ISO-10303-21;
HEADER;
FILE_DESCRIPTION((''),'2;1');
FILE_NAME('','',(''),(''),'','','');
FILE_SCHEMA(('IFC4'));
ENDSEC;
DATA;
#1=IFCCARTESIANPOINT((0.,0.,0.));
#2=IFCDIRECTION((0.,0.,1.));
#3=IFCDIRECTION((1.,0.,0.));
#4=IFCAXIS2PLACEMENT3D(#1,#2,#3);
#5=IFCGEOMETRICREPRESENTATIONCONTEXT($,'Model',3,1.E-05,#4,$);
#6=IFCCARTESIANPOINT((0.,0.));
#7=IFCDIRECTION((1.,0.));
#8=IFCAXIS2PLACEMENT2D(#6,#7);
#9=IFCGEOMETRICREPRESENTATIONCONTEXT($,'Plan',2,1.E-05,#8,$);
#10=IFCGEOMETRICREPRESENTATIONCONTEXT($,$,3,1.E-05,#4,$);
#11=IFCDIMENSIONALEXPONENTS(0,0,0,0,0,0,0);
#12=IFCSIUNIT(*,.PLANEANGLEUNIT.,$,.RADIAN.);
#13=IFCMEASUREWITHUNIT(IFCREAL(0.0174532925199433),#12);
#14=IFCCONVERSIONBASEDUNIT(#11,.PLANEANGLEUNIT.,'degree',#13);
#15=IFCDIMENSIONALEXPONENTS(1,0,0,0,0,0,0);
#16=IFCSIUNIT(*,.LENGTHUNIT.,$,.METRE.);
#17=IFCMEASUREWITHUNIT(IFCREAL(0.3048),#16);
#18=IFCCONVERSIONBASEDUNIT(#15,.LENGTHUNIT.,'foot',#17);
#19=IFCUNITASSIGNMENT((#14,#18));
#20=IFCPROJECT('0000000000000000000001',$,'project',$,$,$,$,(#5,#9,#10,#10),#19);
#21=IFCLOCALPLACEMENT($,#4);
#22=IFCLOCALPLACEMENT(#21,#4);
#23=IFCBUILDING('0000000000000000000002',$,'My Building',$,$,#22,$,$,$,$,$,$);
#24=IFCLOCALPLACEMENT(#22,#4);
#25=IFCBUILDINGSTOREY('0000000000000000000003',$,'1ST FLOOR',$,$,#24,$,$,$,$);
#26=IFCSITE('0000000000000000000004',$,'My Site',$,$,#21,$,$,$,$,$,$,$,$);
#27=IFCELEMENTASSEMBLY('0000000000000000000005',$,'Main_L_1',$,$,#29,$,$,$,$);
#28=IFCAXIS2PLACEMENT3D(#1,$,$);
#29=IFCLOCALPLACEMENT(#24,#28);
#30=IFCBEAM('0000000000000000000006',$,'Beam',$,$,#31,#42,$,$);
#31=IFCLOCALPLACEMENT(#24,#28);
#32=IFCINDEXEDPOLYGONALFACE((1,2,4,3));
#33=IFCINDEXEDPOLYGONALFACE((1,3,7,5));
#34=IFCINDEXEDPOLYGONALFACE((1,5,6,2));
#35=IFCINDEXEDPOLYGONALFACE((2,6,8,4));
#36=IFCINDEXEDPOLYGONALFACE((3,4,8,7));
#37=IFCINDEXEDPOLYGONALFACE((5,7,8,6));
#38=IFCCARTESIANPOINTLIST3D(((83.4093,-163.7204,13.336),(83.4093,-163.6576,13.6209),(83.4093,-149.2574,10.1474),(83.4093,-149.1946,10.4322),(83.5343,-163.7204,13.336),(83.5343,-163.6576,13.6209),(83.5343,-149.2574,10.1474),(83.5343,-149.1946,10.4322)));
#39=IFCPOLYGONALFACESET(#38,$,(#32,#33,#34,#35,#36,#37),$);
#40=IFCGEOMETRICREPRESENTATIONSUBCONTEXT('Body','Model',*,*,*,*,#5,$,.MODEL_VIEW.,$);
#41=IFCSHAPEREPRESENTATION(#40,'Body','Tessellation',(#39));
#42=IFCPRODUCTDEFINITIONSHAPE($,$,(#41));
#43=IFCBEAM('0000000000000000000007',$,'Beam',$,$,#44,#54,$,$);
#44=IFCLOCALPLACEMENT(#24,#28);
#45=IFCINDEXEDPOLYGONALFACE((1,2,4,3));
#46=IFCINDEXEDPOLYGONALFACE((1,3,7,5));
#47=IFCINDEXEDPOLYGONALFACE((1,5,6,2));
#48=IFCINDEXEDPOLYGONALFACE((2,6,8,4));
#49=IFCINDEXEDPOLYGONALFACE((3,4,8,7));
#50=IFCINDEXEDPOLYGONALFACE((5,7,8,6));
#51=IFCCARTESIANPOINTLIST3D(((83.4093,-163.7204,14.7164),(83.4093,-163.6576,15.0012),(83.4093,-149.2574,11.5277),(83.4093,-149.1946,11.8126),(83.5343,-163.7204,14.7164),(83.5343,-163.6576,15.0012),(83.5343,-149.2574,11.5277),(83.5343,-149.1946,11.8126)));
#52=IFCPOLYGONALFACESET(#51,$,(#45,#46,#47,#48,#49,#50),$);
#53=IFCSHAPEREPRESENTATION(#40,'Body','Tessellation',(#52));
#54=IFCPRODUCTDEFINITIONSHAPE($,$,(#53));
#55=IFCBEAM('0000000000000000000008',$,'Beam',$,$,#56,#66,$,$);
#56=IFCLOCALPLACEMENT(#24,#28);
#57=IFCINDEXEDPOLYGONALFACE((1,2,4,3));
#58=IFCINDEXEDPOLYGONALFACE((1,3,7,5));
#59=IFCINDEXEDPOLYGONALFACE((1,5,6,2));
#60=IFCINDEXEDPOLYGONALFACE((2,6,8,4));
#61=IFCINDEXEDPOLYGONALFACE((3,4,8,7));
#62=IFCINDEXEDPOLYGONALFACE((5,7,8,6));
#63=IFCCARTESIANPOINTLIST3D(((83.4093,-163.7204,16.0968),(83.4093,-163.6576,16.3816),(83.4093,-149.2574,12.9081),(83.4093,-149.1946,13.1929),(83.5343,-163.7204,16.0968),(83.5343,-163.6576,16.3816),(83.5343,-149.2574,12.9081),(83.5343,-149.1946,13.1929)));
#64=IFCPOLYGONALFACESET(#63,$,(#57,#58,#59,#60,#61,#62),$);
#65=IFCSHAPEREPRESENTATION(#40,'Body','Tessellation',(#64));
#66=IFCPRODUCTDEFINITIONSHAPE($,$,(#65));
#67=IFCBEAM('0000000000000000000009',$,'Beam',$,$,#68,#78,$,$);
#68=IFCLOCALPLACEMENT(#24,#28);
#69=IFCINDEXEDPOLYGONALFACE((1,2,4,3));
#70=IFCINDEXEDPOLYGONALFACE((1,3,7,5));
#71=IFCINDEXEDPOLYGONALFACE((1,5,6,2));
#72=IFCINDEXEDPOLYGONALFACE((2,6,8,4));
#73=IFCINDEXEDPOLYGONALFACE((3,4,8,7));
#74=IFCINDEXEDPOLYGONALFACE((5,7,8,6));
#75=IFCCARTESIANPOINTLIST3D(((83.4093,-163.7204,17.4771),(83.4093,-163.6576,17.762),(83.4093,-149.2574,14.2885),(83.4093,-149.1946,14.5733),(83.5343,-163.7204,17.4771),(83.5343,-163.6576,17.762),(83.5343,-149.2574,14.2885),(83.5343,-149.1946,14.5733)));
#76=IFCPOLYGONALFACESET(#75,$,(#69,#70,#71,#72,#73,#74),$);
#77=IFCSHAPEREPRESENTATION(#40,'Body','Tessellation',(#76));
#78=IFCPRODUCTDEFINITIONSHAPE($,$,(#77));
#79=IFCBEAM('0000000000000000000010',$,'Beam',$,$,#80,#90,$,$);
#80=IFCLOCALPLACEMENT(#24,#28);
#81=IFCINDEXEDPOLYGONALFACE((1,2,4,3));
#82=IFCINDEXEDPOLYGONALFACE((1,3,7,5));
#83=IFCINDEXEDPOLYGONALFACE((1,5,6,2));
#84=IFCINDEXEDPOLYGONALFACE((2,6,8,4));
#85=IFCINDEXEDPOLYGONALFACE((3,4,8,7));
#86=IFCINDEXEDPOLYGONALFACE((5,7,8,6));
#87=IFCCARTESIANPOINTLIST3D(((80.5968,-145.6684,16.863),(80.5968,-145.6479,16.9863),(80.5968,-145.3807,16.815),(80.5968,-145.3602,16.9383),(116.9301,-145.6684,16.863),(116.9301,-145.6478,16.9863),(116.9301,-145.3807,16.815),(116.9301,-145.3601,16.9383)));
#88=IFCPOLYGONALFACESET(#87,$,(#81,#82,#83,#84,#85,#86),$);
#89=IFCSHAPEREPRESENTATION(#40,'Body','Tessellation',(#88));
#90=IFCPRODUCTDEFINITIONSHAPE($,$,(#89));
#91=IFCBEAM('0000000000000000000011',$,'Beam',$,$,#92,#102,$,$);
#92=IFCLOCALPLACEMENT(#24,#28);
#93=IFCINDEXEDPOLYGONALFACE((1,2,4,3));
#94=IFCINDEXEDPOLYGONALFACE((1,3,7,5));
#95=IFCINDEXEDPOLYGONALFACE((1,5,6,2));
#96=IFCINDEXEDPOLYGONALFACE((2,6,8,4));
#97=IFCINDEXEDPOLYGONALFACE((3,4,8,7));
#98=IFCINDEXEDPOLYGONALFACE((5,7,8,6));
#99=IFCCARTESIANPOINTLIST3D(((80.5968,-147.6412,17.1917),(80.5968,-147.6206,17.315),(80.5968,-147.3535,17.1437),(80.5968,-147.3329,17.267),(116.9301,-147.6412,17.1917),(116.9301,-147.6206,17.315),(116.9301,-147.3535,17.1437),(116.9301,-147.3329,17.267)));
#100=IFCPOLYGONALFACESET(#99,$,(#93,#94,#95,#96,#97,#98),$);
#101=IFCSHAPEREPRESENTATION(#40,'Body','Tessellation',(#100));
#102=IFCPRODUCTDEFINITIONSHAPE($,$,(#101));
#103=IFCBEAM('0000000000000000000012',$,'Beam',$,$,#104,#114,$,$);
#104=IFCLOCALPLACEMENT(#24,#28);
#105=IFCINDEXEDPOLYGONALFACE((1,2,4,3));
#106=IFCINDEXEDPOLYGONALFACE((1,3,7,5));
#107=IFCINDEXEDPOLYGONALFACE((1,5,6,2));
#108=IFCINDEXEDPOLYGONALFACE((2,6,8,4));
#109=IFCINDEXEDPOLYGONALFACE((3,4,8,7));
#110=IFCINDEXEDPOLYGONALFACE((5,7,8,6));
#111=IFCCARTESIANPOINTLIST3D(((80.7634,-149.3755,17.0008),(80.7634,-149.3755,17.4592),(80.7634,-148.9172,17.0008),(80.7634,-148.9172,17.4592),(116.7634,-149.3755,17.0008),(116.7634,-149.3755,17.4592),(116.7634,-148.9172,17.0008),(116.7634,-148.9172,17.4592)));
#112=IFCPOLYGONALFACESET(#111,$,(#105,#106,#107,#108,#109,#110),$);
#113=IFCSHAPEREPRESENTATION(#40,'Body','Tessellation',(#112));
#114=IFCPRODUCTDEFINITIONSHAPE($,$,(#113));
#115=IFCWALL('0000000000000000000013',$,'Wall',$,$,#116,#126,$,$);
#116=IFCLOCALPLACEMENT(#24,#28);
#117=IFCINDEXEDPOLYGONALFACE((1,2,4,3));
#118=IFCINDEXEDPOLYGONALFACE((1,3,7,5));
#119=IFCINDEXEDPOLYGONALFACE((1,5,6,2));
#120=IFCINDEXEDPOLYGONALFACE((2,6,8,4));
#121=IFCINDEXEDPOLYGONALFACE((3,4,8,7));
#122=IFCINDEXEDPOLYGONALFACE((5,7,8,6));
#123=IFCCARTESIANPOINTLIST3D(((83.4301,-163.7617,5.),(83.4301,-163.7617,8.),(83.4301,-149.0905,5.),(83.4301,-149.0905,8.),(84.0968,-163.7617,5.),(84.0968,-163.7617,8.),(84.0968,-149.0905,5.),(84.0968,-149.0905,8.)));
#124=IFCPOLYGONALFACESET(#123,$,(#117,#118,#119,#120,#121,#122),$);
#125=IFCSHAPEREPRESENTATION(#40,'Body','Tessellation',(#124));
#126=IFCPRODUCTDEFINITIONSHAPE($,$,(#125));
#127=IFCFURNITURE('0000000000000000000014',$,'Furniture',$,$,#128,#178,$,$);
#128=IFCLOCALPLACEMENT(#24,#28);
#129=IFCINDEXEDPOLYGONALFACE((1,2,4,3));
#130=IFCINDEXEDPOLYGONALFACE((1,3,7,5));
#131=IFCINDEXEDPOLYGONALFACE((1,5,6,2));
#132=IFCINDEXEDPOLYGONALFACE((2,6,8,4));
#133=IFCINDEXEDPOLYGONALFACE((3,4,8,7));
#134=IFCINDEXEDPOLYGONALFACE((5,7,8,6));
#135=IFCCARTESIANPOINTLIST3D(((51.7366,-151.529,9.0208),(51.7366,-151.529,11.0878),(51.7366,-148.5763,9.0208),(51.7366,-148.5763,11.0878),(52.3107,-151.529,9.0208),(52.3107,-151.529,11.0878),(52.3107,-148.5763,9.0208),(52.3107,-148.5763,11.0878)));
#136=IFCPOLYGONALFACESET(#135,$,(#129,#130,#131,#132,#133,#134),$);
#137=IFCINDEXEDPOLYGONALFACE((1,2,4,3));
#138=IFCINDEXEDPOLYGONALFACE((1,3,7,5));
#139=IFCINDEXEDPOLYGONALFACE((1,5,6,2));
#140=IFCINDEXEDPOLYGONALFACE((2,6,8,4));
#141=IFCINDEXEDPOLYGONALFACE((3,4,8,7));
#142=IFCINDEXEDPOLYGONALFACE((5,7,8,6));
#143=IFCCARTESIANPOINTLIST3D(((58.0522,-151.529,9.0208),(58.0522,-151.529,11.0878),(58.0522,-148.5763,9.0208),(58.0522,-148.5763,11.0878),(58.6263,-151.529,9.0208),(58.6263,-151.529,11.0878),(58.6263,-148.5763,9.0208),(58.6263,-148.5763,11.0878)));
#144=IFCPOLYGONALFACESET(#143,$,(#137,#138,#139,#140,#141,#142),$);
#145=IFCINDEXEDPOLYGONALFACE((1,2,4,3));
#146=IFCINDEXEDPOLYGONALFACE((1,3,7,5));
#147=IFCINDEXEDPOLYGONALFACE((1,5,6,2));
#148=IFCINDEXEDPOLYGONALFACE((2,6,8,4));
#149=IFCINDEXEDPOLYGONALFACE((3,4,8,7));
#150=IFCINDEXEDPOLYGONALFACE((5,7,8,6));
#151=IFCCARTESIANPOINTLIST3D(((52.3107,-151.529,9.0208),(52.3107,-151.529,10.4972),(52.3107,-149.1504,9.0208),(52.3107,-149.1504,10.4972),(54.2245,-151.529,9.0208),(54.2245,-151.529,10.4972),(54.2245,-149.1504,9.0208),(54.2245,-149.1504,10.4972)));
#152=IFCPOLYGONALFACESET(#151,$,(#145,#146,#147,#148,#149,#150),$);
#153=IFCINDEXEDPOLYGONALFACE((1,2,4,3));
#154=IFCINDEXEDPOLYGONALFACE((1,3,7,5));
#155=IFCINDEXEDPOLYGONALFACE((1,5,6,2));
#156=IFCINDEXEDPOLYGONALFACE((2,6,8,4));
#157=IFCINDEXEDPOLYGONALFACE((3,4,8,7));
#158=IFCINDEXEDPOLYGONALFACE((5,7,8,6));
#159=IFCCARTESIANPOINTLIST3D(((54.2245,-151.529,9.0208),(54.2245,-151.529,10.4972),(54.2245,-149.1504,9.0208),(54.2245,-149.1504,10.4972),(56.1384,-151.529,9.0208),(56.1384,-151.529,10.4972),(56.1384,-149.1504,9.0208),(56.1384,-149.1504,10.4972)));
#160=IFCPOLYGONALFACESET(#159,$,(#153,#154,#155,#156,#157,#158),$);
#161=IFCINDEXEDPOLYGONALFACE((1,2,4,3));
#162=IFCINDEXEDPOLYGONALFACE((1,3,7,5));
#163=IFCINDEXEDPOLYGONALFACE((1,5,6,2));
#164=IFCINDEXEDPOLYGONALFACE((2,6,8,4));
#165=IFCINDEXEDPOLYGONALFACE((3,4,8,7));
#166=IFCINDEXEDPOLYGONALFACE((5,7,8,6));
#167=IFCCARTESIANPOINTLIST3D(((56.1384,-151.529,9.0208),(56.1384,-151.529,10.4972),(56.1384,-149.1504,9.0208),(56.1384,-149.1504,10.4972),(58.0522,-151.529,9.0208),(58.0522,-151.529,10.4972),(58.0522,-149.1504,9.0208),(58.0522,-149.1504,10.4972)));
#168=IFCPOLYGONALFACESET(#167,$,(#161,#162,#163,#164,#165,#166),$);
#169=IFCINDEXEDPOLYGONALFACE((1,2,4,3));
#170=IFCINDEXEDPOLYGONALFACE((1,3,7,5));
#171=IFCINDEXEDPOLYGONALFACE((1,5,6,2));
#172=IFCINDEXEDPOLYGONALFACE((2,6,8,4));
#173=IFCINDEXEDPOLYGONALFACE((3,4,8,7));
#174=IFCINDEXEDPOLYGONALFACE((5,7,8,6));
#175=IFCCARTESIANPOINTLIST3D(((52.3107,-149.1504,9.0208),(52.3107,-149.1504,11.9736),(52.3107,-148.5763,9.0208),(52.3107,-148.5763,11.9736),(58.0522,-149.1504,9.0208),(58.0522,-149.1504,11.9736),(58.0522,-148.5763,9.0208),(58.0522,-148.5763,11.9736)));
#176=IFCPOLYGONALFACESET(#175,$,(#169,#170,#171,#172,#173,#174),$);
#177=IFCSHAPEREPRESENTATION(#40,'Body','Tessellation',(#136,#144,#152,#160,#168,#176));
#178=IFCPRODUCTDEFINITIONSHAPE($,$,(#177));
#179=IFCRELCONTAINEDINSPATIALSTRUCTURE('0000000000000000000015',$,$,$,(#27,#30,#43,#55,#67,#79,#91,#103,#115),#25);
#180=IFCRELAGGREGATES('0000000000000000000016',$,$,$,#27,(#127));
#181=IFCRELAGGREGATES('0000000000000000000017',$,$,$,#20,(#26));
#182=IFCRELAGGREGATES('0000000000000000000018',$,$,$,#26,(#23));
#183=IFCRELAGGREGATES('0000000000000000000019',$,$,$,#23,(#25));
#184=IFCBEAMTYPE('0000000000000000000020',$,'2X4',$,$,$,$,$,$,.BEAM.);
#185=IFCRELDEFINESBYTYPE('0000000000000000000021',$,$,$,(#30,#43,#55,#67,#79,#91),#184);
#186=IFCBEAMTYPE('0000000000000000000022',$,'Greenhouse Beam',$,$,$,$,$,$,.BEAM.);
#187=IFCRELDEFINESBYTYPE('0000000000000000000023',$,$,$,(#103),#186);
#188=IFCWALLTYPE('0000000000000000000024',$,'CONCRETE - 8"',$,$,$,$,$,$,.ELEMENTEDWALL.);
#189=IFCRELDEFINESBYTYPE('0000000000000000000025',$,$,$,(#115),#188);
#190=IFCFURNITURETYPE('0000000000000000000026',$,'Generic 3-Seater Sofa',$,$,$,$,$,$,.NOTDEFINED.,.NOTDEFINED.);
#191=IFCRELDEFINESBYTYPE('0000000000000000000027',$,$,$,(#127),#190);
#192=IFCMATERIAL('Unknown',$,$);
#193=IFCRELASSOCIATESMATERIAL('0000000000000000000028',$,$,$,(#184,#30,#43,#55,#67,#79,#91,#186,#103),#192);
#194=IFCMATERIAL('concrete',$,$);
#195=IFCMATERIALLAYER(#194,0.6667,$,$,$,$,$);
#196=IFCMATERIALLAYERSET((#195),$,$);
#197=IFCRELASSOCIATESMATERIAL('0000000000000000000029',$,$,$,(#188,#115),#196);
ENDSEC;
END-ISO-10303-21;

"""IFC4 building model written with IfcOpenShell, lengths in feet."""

from ifc_helpers import new_model, entity, si_unit, converted_unit, frame, origin_with_axes, origin_2d_with_axis, place, context, subcontext, project, spatial, line, indexed_curve, rectangle, outline, extrude, source, transform, mapped, material, layer, layer_set, layer_usage, material_profile, profile_set, profile_usage, type_object, type_shapes, element, aggregate, save


model = new_model("IFC4")

# Units and contexts
model_context = context("Model", 3, precision=1e-05, world=origin_with_axes())
plan_context = context("Plan", 2, precision=1e-05, world=origin_2d_with_axis())
context_of_model = context(None, 3, precision=1e-05, world=origin_with_axes())
body_context = subcontext(model_context, "Body", "Model", "MODEL_VIEW")
ifc_project = project(units=[converted_unit("PLANEANGLEUNIT", "degree", entity("IfcReal", 0.0174532925199433), si_unit("PLANEANGLEUNIT", "RADIAN"), dimensions=[0, 0, 0, 0, 0, 0, 0]), converted_unit("LENGTHUNIT", "foot", entity("IfcReal", 0.3048), si_unit("LENGTHUNIT", "METRE"), dimensions=[1, 0, 0, 0, 0, 0, 0])], contexts=[model_context, plan_context, context_of_model, context_of_model])

# Site, building, storey
site_placement = place(None, origin_with_axes())
site = spatial("IfcSite", under=ifc_project, at=site_placement, Name="My Site")
building_placement = place(site_placement, origin_with_axes())
building = spatial("IfcBuilding", under=site, at=building_placement, Name="My Building")
storey_placement = place(building_placement, origin_with_axes())
storey = spatial("IfcBuildingStorey", under=building, at=storey_placement, Name="1ST FLOOR")

# Element assembly
assembly_placement = place(storey_placement, frame((422.0803, -101.7792, 9.0), z_axis=(0.0, 0.0, 1.0), x_axis=(0.0, -1.0, 0.0)))
assembly = element("IfcElementAssembly", 1, at=assembly_placement, inside=storey, Name="Main_L_1")

# Beams
ifc_material_1 = material(Name="Unknown")
ifc_material_profile_1 = material_profile(ifc_material_1, rectangle(XDim=0.125, YDim=0.2917))
ifc_profile_set_1 = profile_set([ifc_material_profile_1])
ifc_profile_usage_1 = profile_usage(ifc_profile_set_1, cardinal=7)
beam_type_1 = type_object("IfcBeamType", Name="2X4", PredefinedType="BEAM", material=ifc_profile_set_1)
beam_1_placement = place(storey_placement, frame((83.5343, -149.1946, 10.4322), z_axis=(0.0, -0.976548, 0.215302), x_axis=(1.0, 0.0, 0.0)))
element("IfcBeam", 2, at=beam_1_placement, inside=storey, type_object=beam_type_1, material=ifc_profile_usage_1, Name="Beam", context=body_context, shape_type="SweptSolid", body=[
    extrude(rectangle(XDim=0.125, YDim=0.2917), frame((-0.0625, -0.1458, 0.0), z_axis=(0.0, 0.0, 1.0), x_axis=(1.0, 0.0, 0.0)), (0.0, 0.0, 1.0), 14.8103),
])
ifc_profile_usage_2 = profile_usage(ifc_profile_set_1, cardinal=7)
beam_2_placement = place(storey_placement, frame((83.5343, -149.1946, 11.8126), z_axis=(0.0, -0.976548, 0.215302), x_axis=(1.0, 0.0, 0.0)))
element("IfcBeam", 3, at=beam_2_placement, inside=storey, type_object=beam_type_1, material=ifc_profile_usage_2, Name="Beam", context=body_context, shape_type="SweptSolid", body=[
    extrude(rectangle(XDim=0.125, YDim=0.2917), frame((-0.0625, -0.1458, 0.0), z_axis=(0.0, 0.0, 1.0), x_axis=(1.0, 0.0, 0.0)), (0.0, 0.0, 1.0), 14.8103),
])
ifc_profile_usage_3 = profile_usage(ifc_profile_set_1, cardinal=7)
beam_3_placement = place(storey_placement, frame((83.5343, -149.1946, 13.1929), z_axis=(0.0, -0.976548, 0.215302), x_axis=(1.0, 0.0, 0.0)))
element("IfcBeam", 4, at=beam_3_placement, inside=storey, type_object=beam_type_1, material=ifc_profile_usage_3, Name="Beam", context=body_context, shape_type="SweptSolid", body=[
    extrude(rectangle(XDim=0.125, YDim=0.2917), frame((-0.0625, -0.1458, 0.0), z_axis=(0.0, 0.0, 1.0), x_axis=(1.0, 0.0, 0.0)), (0.0, 0.0, 1.0), 14.8103),
])
ifc_profile_usage_4 = profile_usage(ifc_profile_set_1, cardinal=7)
beam_4_placement = place(storey_placement, frame((83.5343, -149.1946, 14.5733), z_axis=(0.0, -0.976548, 0.215302), x_axis=(1.0, 0.0, 0.0)))
element("IfcBeam", 5, at=beam_4_placement, inside=storey, type_object=beam_type_1, material=ifc_profile_usage_4, Name="Beam", context=body_context, shape_type="SweptSolid", body=[
    extrude(rectangle(XDim=0.125, YDim=0.2917), frame((-0.0625, -0.1458, 0.0), z_axis=(0.0, 0.0, 1.0), x_axis=(1.0, 0.0, 0.0)), (0.0, 0.0, 1.0), 14.8103),
])
ifc_profile_usage_5 = profile_usage(ifc_profile_set_1, cardinal=5)
beam_5_placement = place(storey_placement, frame((80.5968, -145.5143, 16.9006), z_axis=(1.0, 0.000001, 0.0), x_axis=(0.0, -0.164359, -0.986401)))
element("IfcBeam", 6, at=beam_5_placement, inside=storey, type_object=beam_type_1, material=ifc_profile_usage_5, Name="Beam", context=body_context, shape_type="SweptSolid", body=[
    extrude(rectangle(XDim=0.125, YDim=0.2917), origin_with_axes(), (0.0, 0.0, 1.0), 36.3334),
])
ifc_profile_usage_6 = profile_usage(ifc_profile_set_1, cardinal=5)
beam_6_placement = place(storey_placement, frame((80.5968, -147.4871, 17.2294), z_axis=(1.0, 0.000001, 0.0), x_axis=(0.0, -0.164359, -0.986401)))
element("IfcBeam", 7, at=beam_6_placement, inside=storey, type_object=beam_type_1, material=ifc_profile_usage_6, Name="Beam", context=body_context, shape_type="SweptSolid", body=[
    extrude(rectangle(XDim=0.125, YDim=0.2917), origin_with_axes(), (0.0, 0.0, 1.0), 36.3334),
])

# Beam
ifc_material_profile_2 = material_profile(ifc_material_1, rectangle(XDim=0.4583, YDim=0.4583))
ifc_profile_set_2 = profile_set([ifc_material_profile_2])
ifc_profile_usage_7 = profile_usage(ifc_profile_set_2)
beam_type_2 = type_object("IfcBeamType", Name="Greenhouse Beam", PredefinedType="BEAM", material=ifc_profile_set_2)
beam_7_placement = place(storey_placement, frame((80.7634, -149.1464, 17.23), z_axis=(1.0, 0.0, 0.0), x_axis=(0.0, 1.0, 0.0)))
element("IfcBeam", 8, at=beam_7_placement, inside=storey, type_object=beam_type_2, material=ifc_profile_usage_7, Name="Beam", context=body_context, shape_type="SweptSolid", body=[
    extrude(rectangle(XDim=0.4583, YDim=0.4583), origin_with_axes(), (0.0, 0.0, 1.0), 36.0),
])

# Wall
ifc_material_2 = material(Name="concrete")
ifc_layer_1 = layer(ifc_material_2, 0.6667)
ifc_layer_set_1 = layer_set([ifc_layer_1])
ifc_layer_usage_1 = layer_usage(ifc_layer_set_1, "AXIS2", "POSITIVE", 0.0)
wall_type_1 = type_object("IfcWallType", Name="CONCRETE - 8\"", PredefinedType="ELEMENTEDWALL", material=ifc_layer_set_1)
wall_1_placement = place(storey_placement, frame((83.4301, -149.0905, 5.0), z_axis=(0.0, 0.0, 1.0), x_axis=(0.0, -1.0, 0.0)))
element("IfcWall", 9, at=wall_1_placement, inside=storey, type_object=wall_type_1, material=ifc_layer_usage_1, Name="Wall", context=body_context, shape_type="SweptSolid", body=[
    extrude(outline(indexed_curve([(0.0, 0.0), (0.0, 0.6667), (14.6713, 0.6667), (14.6713, 0.0), (0.0, 0.0)], self_intersect=False)), origin_with_axes(), (0.0, 0.0, 1.0), 3.0),
])

# Furniture
furniture_type = type_object("IfcFurnitureType", Name="Generic 3-Seater Sofa", AssemblyPlace="NOTDEFINED", PredefinedType="NOTDEFINED")
shared_shape_1 = source(origin_with_axes(), body_context, "Body", "SweptSolid", [
    extrude(outline(indexed_curve([(0.0, 0.0), (0.5741, 0.0), (0.5741, 2.9528), (0.0, 2.9528)], segments=[line(1, 2), line(2, 3), line(3, 4), line(4, 1)])), frame((-3.4449, -2.9528, 0.0), z_axis=(0.0, 0.0, 1.0), x_axis=(1.0, 0.0, 0.0)), (0.0, 0.0, 1.0), 2.0669),
    extrude(outline(indexed_curve([(0.0, 0.0), (0.5741, 0.0), (0.5741, 2.9528), (0.0, 2.9528)], segments=[line(1, 2), line(2, 3), line(3, 4), line(4, 1)])), frame((2.8707, -2.9528, 0.0), z_axis=(0.0, 0.0, 1.0), x_axis=(1.0, 0.0, 0.0)), (0.0, 0.0, 1.0), 2.0669),
    extrude(outline(indexed_curve([(0.5741, 0.0), (2.488, 0.0), (2.488, 2.3786), (0.5741, 2.3786)], segments=[line(1, 2), line(2, 3), line(3, 4), line(4, 1)])), frame((-3.4449, -2.9528, 0.0), z_axis=(0.0, 0.0, 1.0), x_axis=(1.0, 0.0, 0.0)), (0.0, 0.0, 1.0), 1.4764),
    extrude(outline(indexed_curve([(2.488, 0.0), (4.4018, 0.0), (4.4018, 2.3786), (2.488, 2.3786)], segments=[line(1, 2), line(2, 3), line(3, 4), line(4, 1)])), frame((-3.4449, -2.9528, 0.0), z_axis=(0.0, 0.0, 1.0), x_axis=(1.0, 0.0, 0.0)), (0.0, 0.0, 1.0), 1.4764),
    extrude(outline(indexed_curve([(4.4018, 0.0), (6.3156, 0.0), (6.3156, 2.3786), (4.4018, 2.3786)], segments=[line(1, 2), line(2, 3), line(3, 4), line(4, 1)])), frame((-3.4449, -2.9528, 0.0), z_axis=(0.0, 0.0, 1.0), x_axis=(1.0, 0.0, 0.0)), (0.0, 0.0, 1.0), 1.4764),
    extrude(outline(indexed_curve([(0.5741, 2.3786), (6.3156, 2.3786), (6.3156, 2.9528), (0.5741, 2.9528)], segments=[line(1, 2), line(2, 3), line(3, 4), line(4, 1)])), frame((-3.4449, -2.9528, 0.0), z_axis=(0.0, 0.0, 1.0), x_axis=(1.0, 0.0, 0.0)), (0.0, 0.0, 1.0), 2.9528),
])
type_shapes(furniture_type, [shared_shape_1])
furniture_placement = place(assembly_placement, frame((46.7969, -366.8989, 0.0208), z_axis=(0.0, 0.0, 1.0), x_axis=(0.0, 1.0, 0.0)))
furniture = element("IfcFurniture", 10, at=furniture_placement, type_object=furniture_type, Name="Furniture", context=body_context, shape_type="MappedRepresentation", body=[
    mapped(shared_shape_1, transform((0.0, 0.0, 0.0), x_axis=(1.0, 0.0, 0.0), y_axis=(0.0, 1.0, 0.0), z_axis=(0.0, 0.0, 1.0), scale=1.0)),
])
aggregate(assembly, [furniture])

save(model, "model.ifc")
